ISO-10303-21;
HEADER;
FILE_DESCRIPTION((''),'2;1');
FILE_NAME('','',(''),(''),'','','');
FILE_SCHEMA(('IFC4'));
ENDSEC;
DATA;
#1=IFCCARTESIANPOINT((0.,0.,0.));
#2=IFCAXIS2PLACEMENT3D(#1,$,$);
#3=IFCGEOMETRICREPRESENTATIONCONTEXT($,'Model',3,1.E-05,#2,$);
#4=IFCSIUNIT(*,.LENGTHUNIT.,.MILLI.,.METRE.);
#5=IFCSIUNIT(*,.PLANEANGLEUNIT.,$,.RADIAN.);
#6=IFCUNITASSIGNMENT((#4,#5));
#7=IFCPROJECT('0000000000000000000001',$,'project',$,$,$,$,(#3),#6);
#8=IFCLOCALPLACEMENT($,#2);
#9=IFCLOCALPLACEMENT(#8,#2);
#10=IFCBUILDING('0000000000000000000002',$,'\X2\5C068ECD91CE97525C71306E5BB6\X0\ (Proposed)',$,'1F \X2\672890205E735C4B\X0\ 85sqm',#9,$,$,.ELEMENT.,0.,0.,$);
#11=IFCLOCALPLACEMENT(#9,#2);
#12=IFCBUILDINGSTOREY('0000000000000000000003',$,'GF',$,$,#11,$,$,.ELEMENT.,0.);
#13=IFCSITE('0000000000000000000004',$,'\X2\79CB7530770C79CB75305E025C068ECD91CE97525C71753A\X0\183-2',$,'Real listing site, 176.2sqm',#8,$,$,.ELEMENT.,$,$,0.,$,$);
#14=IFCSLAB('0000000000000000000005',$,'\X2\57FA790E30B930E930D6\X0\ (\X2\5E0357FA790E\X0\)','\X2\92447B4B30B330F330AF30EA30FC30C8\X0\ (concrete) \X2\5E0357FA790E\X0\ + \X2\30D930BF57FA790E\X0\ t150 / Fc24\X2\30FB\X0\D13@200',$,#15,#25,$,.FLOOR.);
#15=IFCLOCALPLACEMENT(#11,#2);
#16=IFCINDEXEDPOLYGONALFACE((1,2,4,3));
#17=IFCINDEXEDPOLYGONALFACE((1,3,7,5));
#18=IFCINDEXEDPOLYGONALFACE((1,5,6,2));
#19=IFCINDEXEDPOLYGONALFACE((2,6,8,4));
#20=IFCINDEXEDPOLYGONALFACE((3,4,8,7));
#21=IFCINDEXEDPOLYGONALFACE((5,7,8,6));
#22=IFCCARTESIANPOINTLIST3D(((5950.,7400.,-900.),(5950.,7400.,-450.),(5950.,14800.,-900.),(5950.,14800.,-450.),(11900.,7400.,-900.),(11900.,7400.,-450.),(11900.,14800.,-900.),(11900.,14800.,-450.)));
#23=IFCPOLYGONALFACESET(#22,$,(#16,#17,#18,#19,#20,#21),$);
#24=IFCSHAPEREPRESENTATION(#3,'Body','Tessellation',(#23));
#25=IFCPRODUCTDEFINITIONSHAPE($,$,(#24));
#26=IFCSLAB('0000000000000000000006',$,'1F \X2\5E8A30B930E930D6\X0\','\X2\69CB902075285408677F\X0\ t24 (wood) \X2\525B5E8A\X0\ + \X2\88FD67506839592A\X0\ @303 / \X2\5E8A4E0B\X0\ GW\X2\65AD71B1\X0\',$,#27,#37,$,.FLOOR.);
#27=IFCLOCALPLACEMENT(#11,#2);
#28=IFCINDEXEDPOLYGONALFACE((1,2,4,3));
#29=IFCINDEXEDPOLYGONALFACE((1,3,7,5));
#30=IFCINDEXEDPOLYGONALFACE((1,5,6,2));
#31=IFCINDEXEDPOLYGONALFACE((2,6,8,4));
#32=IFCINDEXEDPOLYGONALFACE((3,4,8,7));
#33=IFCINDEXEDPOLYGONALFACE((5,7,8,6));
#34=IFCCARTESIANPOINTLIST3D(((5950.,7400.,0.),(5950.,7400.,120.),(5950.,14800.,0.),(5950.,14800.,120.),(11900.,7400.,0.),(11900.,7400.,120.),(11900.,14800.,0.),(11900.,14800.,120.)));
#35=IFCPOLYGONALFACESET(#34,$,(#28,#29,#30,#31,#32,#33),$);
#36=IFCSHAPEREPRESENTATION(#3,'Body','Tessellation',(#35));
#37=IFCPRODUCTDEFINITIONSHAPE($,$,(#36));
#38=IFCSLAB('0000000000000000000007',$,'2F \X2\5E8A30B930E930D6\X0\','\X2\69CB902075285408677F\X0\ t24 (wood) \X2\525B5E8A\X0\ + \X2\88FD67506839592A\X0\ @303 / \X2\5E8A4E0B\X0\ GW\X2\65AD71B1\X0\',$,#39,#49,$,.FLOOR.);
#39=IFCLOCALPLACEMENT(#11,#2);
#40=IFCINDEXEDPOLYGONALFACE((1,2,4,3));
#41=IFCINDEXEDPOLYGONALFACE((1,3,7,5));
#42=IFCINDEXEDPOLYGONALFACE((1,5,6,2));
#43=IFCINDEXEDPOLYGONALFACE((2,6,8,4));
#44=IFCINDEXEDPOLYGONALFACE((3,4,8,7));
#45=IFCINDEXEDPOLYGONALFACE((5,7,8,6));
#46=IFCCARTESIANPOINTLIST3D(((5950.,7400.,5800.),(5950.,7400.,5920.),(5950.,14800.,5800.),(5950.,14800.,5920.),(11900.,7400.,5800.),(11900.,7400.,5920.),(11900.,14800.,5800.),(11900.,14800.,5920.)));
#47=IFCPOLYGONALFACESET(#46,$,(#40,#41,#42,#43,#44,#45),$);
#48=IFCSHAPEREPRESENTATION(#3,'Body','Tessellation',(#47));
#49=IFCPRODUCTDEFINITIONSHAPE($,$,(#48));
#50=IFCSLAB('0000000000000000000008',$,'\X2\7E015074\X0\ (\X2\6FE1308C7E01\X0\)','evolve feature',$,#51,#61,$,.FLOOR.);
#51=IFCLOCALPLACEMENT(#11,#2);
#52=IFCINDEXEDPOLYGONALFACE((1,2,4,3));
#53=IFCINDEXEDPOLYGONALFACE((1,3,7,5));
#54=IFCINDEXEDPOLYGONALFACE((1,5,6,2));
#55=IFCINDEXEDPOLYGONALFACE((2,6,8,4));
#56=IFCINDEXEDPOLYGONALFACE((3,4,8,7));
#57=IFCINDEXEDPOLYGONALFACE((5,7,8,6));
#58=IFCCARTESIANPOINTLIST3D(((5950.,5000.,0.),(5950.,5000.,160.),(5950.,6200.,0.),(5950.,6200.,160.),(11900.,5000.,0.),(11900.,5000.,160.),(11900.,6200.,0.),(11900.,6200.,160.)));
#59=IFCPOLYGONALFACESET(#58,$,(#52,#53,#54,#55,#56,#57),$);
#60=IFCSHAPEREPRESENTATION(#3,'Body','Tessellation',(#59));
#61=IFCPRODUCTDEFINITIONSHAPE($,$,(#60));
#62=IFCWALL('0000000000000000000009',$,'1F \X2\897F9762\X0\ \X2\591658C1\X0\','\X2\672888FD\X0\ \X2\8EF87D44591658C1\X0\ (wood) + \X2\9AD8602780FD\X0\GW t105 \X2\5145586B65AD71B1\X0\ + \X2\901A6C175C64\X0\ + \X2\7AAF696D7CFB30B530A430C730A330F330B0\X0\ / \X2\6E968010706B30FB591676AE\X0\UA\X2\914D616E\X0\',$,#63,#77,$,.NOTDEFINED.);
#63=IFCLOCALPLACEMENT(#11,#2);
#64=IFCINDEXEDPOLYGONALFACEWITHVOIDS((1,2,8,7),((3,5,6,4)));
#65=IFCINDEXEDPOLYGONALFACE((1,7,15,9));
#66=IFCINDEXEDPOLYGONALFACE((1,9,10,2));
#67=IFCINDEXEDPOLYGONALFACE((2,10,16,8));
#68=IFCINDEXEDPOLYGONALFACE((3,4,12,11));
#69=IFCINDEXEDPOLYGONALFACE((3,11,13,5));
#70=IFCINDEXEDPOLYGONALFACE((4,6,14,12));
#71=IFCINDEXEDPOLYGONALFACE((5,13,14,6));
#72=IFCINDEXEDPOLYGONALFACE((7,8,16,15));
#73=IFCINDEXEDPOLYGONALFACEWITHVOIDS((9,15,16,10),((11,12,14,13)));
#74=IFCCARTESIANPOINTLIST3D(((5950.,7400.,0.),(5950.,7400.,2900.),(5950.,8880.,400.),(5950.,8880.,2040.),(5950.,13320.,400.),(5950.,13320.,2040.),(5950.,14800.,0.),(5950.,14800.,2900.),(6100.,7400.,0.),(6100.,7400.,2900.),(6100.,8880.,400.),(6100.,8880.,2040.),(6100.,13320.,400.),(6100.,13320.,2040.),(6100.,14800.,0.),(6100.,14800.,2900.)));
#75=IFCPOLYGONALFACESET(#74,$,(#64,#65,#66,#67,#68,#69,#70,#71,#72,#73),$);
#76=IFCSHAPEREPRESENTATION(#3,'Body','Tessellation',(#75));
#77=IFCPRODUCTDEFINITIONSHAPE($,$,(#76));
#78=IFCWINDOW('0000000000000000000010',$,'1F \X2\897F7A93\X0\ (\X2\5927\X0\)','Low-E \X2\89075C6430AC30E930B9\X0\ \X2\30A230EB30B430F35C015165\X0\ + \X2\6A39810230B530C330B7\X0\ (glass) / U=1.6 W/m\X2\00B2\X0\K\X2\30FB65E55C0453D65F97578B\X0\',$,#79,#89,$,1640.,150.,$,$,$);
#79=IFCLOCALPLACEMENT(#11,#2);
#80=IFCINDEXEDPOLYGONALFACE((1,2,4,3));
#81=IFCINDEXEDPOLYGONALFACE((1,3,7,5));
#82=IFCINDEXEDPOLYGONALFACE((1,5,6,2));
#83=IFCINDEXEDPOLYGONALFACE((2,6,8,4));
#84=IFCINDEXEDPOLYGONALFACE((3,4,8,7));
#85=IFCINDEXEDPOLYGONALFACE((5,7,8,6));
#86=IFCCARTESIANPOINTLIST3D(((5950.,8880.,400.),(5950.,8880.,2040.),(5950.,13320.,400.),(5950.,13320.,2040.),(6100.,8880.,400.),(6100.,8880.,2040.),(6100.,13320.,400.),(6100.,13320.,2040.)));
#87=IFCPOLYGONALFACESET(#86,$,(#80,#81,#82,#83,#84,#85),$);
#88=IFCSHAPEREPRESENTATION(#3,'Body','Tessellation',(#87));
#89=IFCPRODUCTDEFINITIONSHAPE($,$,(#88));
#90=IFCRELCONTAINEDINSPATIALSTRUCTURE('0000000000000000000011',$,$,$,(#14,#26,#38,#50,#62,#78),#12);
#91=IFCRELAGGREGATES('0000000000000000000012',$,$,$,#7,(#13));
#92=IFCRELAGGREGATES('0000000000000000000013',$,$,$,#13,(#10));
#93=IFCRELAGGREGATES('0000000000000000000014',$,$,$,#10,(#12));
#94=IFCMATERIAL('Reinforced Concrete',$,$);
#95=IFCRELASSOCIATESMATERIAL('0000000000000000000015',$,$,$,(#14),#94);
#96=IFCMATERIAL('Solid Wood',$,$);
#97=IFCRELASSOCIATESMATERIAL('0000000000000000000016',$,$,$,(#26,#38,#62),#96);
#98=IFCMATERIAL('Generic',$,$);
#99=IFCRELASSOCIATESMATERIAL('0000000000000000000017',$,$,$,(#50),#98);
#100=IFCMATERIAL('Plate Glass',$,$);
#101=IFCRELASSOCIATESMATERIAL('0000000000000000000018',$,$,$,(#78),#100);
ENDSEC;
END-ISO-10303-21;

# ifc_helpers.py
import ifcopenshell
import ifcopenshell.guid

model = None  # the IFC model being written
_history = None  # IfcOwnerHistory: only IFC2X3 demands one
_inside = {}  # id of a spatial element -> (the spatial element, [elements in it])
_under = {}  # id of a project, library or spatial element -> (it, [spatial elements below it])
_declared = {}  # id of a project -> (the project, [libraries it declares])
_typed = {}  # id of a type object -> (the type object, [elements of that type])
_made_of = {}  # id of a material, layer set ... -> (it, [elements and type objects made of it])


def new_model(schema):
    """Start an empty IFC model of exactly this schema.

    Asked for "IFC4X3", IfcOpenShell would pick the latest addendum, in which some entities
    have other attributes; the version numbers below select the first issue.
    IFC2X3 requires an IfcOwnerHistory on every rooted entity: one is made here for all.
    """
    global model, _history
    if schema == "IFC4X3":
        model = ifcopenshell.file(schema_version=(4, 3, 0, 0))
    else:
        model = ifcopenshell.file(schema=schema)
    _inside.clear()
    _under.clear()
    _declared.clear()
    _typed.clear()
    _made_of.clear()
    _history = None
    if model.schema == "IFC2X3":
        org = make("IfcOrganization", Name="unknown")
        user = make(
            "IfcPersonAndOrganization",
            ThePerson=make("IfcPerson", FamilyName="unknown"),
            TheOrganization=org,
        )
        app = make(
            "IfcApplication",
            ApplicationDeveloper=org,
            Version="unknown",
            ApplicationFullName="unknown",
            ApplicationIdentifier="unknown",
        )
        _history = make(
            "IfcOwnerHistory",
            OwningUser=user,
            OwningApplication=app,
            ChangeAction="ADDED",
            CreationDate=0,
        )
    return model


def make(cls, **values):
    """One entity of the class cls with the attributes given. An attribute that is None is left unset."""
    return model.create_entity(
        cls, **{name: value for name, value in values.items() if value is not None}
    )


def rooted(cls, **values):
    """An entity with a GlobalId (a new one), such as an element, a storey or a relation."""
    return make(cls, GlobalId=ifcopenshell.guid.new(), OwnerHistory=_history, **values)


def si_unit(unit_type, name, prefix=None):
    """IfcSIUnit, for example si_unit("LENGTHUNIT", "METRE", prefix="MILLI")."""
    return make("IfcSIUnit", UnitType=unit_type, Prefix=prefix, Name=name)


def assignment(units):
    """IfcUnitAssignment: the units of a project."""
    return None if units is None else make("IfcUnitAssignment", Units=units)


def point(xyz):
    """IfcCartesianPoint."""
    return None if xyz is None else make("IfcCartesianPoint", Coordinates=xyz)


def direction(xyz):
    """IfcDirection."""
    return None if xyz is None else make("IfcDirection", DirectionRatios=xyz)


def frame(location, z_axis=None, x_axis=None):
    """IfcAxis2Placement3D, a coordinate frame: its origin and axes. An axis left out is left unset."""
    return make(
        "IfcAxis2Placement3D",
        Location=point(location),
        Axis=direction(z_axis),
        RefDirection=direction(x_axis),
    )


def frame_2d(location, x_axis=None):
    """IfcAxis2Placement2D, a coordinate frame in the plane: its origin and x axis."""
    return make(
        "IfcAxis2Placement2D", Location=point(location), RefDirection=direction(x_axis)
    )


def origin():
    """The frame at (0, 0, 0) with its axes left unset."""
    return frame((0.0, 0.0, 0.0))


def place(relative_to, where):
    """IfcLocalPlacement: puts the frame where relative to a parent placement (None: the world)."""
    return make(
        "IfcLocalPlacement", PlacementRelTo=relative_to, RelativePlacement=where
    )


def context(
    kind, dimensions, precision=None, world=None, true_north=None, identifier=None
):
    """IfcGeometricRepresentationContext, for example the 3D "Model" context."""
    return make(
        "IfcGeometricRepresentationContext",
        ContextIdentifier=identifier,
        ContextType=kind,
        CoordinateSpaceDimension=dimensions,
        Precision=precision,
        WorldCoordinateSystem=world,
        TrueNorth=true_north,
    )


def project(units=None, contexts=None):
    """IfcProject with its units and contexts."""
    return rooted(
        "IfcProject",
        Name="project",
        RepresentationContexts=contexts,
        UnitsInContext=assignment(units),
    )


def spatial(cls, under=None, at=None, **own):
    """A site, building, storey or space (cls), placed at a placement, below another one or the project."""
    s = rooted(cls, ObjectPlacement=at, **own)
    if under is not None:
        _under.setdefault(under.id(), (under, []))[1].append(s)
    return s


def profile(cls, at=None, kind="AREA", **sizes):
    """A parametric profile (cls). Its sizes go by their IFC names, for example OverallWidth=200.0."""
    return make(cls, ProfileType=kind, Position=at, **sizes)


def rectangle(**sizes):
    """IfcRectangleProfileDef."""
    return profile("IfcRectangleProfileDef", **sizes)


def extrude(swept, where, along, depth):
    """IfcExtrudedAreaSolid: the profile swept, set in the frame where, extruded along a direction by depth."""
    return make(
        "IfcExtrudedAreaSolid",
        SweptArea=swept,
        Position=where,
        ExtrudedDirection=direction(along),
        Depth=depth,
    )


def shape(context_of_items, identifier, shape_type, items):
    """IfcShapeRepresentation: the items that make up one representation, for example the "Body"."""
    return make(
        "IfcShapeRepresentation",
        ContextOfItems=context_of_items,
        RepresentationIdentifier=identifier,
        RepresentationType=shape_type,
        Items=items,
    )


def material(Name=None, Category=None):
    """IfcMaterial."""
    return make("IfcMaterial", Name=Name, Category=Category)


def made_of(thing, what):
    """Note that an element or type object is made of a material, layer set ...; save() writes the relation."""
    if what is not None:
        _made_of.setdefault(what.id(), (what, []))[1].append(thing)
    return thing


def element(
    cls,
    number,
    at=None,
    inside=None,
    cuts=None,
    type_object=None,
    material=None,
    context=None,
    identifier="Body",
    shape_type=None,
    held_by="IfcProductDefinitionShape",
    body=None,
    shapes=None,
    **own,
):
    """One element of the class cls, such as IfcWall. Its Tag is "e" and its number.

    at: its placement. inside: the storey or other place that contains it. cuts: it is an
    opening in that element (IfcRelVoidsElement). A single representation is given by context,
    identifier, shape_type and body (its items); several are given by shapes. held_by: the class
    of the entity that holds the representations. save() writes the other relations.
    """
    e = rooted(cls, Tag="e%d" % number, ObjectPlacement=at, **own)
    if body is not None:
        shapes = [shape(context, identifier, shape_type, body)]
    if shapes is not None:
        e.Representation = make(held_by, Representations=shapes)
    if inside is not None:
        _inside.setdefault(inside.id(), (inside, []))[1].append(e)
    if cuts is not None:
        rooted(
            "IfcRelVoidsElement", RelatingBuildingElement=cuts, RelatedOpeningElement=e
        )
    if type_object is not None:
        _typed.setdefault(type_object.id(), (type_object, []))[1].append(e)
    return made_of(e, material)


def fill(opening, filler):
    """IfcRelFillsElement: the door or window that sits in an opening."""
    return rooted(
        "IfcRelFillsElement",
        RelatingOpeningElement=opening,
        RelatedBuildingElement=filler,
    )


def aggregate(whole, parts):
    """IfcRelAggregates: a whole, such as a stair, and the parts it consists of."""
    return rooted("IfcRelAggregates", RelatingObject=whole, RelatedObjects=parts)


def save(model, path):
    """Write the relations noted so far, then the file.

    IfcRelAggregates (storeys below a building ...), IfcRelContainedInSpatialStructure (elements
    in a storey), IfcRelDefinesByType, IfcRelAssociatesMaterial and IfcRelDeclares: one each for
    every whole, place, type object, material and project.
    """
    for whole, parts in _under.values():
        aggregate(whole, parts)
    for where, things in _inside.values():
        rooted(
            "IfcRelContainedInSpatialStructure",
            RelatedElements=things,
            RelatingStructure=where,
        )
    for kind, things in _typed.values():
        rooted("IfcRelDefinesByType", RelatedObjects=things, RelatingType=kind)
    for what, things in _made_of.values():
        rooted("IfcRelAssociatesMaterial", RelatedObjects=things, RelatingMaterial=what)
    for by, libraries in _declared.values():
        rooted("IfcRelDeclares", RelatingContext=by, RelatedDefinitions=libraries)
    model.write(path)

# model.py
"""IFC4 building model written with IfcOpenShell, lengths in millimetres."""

from ifc_helpers import new_model, si_unit, frame, frame_2d, origin, place, context, project, spatial, rectangle, extrude, material, element, fill, save


model = new_model("IFC4")

# Units and contexts
model_context = context("Model", 3, precision=1e-05, world=origin())
ifc_project = project(units=[si_unit("LENGTHUNIT", "METRE", prefix="MILLI"), si_unit("PLANEANGLEUNIT", "RADIAN")], contexts=[model_context])

# Site, building, storey
site_placement = place(None, origin())
site = spatial("IfcSite", under=ifc_project, at=site_placement, Name="秋田県秋田市将軍野青山町183-2", ObjectType="Real listing site, 176.2sqm", CompositionType="ELEMENT", RefElevation=0.0)
building_placement = place(site_placement, origin())
building = spatial("IfcBuilding", under=site, at=building_placement, Name="将軍野青山の家 (Proposed)", ObjectType="1F 木造平屋 85sqm", CompositionType="ELEMENT", ElevationOfRefHeight=0.0, ElevationOfTerrain=0.0)
storey_placement = place(building_placement, origin())
storey = spatial("IfcBuildingStorey", under=building, at=storey_placement, Name="GF", CompositionType="ELEMENT", Elevation=0.0)

# Slabs
ifc_material_1 = material(Name="Reinforced Concrete")
slab_1_placement = place(storey_placement, frame((2975.0, 3700.0, -450.0)))
element("IfcSlab", 1, at=slab_1_placement, inside=storey, material=ifc_material_1, Name="基礎スラブ (布基礎)", Description="鉄筋コンクリート (concrete) 布基礎 + ベタ基礎 t150 / Fc24・D13@200", PredefinedType="FLOOR", context=model_context, shape_type="SweptSolid", body=[
    extrude(rectangle(XDim=5950.0, YDim=7400.0, at=frame_2d((2975.0, 3700.0))), frame((2975.0, 3700.0, -450.0)), (0.0, 0.0, 1.0), 450.0),
])
ifc_material_2 = material(Name="Solid Wood")
slab_2_placement = place(storey_placement, frame((2975.0, 3700.0, 0.0)))
element("IfcSlab", 2, at=slab_2_placement, inside=storey, material=ifc_material_2, Name="1F 床スラブ", Description="構造用合板 t24 (wood) 剛床 + 製材根太 @303 / 床下 GW断熱", PredefinedType="FLOOR", context=model_context, shape_type="SweptSolid", body=[
    extrude(rectangle(XDim=5950.0, YDim=7400.0, at=frame_2d((2975.0, 3700.0))), frame((2975.0, 3700.0, 0.0)), (0.0, 0.0, 1.0), 120.0),
])
slab_3_placement = place(storey_placement, frame((2975.0, 3700.0, 2900.0)))
element("IfcSlab", 3, at=slab_3_placement, inside=storey, material=ifc_material_2, Name="2F 床スラブ", Description="構造用合板 t24 (wood) 剛床 + 製材根太 @303 / 床下 GW断熱", PredefinedType="FLOOR", context=model_context, shape_type="SweptSolid", body=[
    extrude(rectangle(XDim=5950.0, YDim=7400.0, at=frame_2d((2975.0, 3700.0))), frame((2975.0, 3700.0, 2900.0)), (0.0, 0.0, 1.0), 120.0),
])
ifc_material_3 = material(Name="Generic")
slab_4_placement = place(storey_placement, frame((2975.0, 2500.0, 0.0)))
element("IfcSlab", 4, at=slab_4_placement, inside=storey, material=ifc_material_3, Name="縁側 (濡れ縁)", Description="evolve feature", PredefinedType="FLOOR", context=model_context, shape_type="SweptSolid", body=[
    extrude(rectangle(XDim=5950.0, YDim=1200.0, at=frame_2d((2975.0, 600.0))), frame((2975.0, 2500.0, 0.0)), (0.0, 0.0, 1.0), 160.0),
])

# Shared definitions
ifc_material_4 = material(Name="Plate Glass")

# Wall, opening, window
wall_1_placement = place(storey_placement, frame((2975.0, 3700.0, 0.0)))
wall_1 = element("IfcWall", 5, at=wall_1_placement, inside=storey, material=ifc_material_2, Name="1F 西面 外壁", Description="木製 軸組外壁 (wood) + 高性能GW t105 充填断熱 + 通気層 + 窯業系サイディング / 準耐火・外皮UA配慮", PredefinedType="NOTDEFINED", context=model_context, shape_type="SweptSolid", body=[
    extrude(rectangle(XDim=150.0, YDim=7400.0, at=frame_2d((75.0, 3700.0))), frame((2975.0, 3700.0, 0.0)), (0.0, 0.0, 1.0), 2900.0),
])
opening_1_placement = place(storey_placement, frame((2975.0, 4440.0, 200.0)))
opening_1 = element("IfcOpeningElement", 6, at=opening_1_placement, cuts=wall_1, PredefinedType="NOTDEFINED", context=model_context, shape_type="SweptSolid", body=[
    extrude(rectangle(XDim=150.0, YDim=4440.0, at=frame_2d((75.0, 2220.0))), frame((2975.0, 4440.0, 200.0)), (0.0, 0.0, 1.0), 1640.0),
])
window_1_placement = place(storey_placement, frame((2975.0, 4440.0, 200.0)))
window_1 = element("IfcWindow", 7, at=window_1_placement, inside=storey, material=ifc_material_4, Name="1F 西窓 (大)", Description="Low-E 複層ガラス アルゴン封入 + 樹脂サッシ (glass) / U=1.6 W/m²K・日射取得型", OverallHeight=1640.0, OverallWidth=150.0, context=model_context, shape_type="SweptSolid", body=[
    extrude(rectangle(XDim=150.0, YDim=4440.0, at=frame_2d((75.0, 2220.0))), frame((2975.0, 4440.0, 200.0)), (0.0, 0.0, 1.0), 1640.0),
])
fill(opening_1, window_1)

save(model, "model.ifc")
